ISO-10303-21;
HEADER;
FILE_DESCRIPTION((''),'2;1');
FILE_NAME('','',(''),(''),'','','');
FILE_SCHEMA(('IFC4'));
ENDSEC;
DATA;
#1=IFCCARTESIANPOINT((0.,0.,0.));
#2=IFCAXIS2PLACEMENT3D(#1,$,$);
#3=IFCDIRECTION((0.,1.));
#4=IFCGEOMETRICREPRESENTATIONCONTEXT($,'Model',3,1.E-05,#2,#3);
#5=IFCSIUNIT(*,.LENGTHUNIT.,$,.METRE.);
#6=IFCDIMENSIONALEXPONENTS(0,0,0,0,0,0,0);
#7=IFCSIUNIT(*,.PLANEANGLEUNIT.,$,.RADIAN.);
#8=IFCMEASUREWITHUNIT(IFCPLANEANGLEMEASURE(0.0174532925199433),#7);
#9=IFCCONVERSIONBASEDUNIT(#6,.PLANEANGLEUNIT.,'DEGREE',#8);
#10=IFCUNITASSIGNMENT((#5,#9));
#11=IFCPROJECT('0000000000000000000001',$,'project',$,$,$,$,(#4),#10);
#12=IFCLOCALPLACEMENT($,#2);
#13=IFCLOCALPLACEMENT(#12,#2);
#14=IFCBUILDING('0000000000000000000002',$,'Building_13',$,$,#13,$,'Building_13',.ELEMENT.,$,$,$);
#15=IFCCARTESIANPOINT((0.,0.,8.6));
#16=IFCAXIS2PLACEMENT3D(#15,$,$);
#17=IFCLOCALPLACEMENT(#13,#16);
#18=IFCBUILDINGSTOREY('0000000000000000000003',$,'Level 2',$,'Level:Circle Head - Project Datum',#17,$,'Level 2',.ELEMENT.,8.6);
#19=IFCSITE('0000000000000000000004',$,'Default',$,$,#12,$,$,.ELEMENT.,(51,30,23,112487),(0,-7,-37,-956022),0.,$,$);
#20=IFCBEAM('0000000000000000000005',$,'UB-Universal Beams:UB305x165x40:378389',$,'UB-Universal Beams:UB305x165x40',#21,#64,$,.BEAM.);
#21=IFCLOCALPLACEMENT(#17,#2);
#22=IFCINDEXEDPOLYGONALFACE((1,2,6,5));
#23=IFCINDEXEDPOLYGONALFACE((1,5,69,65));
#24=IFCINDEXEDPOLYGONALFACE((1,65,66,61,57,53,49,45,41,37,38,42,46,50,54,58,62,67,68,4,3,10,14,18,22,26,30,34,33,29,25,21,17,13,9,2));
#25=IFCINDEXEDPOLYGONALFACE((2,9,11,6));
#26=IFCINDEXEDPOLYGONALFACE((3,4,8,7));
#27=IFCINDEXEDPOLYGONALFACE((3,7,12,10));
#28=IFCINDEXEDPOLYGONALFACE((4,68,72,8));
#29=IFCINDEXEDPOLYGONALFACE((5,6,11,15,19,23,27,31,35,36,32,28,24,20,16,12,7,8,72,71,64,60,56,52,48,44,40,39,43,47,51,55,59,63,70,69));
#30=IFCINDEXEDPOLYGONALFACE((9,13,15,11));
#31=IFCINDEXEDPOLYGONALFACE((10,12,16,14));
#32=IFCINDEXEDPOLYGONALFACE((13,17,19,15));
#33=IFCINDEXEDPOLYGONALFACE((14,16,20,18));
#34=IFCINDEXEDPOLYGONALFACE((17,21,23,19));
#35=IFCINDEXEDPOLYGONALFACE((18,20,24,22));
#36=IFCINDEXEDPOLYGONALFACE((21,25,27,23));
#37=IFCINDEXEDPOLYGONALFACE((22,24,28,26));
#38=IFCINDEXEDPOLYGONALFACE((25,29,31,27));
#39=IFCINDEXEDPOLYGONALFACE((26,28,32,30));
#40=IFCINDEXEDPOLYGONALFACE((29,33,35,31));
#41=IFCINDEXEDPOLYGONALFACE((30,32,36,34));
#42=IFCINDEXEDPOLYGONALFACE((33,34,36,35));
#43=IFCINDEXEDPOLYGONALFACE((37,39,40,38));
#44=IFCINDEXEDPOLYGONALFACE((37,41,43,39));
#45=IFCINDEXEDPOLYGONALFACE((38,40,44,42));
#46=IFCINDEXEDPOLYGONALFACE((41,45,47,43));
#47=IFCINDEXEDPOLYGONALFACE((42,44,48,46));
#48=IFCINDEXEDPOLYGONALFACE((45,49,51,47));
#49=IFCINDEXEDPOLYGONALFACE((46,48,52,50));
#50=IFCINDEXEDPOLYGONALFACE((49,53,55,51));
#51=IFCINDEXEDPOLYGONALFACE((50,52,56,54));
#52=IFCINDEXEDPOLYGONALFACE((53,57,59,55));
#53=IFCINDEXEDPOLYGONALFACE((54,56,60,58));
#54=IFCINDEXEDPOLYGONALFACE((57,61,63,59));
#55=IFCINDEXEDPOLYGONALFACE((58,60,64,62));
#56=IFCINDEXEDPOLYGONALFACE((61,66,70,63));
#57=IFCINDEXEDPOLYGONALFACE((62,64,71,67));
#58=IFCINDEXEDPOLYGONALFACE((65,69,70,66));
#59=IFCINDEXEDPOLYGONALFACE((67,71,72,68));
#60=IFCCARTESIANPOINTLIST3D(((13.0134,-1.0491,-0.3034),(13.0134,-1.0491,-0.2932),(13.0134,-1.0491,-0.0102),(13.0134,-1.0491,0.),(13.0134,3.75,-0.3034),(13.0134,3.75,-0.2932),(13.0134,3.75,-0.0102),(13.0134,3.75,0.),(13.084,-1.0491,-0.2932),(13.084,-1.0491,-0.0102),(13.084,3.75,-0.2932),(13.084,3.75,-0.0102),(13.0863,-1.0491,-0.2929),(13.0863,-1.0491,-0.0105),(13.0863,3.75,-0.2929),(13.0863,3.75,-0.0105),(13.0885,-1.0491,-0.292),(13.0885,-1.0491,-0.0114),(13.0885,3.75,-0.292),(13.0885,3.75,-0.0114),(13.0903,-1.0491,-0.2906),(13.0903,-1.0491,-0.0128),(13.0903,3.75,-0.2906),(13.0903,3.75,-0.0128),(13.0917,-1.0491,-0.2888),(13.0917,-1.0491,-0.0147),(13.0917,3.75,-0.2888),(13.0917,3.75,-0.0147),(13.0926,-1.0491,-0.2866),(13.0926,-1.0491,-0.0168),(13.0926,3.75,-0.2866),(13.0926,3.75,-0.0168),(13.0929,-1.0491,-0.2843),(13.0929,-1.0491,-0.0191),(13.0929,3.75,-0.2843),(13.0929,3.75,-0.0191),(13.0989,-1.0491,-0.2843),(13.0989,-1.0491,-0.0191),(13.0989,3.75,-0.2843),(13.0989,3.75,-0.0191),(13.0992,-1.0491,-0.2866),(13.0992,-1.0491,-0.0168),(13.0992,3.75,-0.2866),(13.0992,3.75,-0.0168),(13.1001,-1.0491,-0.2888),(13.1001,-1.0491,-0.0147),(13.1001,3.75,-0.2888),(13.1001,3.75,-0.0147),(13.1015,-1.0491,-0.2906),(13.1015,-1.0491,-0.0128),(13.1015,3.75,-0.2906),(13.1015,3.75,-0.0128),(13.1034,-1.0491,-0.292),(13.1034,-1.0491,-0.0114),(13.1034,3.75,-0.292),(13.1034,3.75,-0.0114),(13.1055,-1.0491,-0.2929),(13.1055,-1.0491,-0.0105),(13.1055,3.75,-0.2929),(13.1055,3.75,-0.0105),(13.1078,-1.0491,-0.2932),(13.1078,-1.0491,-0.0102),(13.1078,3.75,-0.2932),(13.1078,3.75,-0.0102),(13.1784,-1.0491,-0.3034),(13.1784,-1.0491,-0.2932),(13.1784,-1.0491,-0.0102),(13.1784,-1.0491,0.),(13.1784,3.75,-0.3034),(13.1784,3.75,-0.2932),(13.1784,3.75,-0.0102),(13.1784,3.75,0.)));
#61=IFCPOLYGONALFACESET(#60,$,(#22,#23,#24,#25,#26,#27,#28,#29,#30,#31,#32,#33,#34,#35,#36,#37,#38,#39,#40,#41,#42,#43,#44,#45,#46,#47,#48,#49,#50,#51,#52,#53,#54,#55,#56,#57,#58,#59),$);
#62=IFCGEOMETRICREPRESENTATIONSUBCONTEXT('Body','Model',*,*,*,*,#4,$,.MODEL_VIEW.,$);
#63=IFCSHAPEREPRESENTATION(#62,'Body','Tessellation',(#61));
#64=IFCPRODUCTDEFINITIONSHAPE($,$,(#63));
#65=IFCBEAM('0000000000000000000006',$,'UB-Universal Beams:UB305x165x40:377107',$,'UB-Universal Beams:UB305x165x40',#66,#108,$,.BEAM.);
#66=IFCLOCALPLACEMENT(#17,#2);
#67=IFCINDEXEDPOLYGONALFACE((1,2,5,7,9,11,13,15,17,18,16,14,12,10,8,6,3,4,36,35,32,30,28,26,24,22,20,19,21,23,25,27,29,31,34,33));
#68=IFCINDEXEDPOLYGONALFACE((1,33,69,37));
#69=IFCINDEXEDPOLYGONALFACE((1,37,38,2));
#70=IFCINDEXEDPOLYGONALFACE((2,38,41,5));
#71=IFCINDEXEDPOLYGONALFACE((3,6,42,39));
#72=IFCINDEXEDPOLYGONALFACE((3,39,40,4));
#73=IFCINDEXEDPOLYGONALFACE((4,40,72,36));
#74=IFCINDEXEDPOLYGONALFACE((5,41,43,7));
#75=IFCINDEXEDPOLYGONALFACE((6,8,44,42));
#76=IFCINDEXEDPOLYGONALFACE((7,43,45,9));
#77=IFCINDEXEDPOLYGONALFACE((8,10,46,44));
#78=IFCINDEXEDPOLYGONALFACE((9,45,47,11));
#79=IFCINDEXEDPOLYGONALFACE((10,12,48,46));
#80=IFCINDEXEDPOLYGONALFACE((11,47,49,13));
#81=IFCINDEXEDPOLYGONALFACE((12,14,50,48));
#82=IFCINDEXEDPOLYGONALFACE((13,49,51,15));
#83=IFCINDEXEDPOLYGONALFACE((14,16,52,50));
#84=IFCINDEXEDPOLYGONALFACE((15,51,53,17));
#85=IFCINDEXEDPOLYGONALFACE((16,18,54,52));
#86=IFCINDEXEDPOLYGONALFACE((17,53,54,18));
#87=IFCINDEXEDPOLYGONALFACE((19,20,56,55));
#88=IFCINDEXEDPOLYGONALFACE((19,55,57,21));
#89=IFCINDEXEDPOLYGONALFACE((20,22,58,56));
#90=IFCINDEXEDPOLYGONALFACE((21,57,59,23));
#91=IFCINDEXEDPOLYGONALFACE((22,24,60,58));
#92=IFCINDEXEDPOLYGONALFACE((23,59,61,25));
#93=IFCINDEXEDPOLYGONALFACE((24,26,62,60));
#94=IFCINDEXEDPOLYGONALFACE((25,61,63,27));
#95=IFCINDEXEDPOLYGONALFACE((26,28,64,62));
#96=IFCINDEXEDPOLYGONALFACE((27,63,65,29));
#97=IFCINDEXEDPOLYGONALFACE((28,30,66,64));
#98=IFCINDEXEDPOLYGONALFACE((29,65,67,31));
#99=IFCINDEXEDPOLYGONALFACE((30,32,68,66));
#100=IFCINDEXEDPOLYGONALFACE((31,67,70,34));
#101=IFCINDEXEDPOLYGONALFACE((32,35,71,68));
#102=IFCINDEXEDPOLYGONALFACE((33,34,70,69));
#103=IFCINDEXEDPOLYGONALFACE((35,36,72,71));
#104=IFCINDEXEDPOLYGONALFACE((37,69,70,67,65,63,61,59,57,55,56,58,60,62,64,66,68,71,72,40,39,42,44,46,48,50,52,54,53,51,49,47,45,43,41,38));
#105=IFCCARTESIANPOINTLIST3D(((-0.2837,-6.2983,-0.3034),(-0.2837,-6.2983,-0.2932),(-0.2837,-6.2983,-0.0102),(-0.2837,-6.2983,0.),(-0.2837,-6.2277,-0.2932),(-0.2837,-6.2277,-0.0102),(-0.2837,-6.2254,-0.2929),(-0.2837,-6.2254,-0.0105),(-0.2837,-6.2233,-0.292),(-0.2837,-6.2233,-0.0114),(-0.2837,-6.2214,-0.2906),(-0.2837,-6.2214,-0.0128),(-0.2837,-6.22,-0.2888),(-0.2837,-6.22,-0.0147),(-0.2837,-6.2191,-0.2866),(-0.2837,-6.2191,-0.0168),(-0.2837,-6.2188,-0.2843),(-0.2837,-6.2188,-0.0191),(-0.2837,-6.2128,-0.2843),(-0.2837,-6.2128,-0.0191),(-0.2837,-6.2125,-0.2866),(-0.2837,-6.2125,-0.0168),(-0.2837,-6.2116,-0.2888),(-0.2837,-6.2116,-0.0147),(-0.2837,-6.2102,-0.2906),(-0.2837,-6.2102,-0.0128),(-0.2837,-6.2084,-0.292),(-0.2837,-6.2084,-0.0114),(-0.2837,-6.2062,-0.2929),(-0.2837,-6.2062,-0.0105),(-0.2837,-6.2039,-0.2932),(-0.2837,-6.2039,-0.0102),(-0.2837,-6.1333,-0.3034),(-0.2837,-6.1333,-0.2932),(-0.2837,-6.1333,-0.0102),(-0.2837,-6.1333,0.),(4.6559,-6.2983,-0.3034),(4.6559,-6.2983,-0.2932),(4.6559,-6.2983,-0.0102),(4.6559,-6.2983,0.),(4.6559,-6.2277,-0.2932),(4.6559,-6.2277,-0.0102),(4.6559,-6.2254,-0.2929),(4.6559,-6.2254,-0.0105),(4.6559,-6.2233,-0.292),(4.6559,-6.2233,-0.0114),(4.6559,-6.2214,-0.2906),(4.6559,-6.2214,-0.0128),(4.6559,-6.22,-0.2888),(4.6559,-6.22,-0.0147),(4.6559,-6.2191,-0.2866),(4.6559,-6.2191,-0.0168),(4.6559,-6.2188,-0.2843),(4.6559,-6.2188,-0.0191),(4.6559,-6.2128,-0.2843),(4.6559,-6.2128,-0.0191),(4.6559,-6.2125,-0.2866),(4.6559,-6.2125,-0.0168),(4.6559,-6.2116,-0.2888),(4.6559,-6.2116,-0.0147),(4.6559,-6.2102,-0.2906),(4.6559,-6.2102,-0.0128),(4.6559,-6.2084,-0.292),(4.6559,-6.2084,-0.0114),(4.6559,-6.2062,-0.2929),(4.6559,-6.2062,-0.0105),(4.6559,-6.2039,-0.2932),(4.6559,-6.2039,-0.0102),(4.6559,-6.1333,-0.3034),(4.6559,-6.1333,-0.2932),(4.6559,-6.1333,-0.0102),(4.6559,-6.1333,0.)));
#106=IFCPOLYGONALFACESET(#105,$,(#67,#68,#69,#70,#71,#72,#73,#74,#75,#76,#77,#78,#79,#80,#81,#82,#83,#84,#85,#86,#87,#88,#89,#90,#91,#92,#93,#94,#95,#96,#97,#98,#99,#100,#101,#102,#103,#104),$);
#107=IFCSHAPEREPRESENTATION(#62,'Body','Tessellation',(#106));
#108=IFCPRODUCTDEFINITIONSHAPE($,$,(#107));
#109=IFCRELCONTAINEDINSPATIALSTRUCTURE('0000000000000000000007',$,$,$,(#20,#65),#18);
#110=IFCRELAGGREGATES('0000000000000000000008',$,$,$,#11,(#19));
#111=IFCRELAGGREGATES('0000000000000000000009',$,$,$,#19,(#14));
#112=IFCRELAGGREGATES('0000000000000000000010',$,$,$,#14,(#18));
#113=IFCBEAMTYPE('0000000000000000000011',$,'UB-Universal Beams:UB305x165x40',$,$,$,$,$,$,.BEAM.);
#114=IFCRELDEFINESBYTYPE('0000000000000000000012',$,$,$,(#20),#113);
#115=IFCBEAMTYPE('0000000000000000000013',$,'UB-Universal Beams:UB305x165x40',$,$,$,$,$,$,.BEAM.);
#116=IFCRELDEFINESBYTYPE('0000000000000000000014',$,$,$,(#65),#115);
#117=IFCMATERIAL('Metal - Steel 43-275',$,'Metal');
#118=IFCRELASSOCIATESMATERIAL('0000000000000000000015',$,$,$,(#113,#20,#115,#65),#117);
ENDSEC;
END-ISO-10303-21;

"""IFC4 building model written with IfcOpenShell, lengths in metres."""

from ifc_helpers import new_model, entity, si_unit, converted_unit, direction, frame, origin, place, context, subcontext, project, spatial, line, arc, indexed_curve, outline, extrude, source, transform, mapped, material, type_object, type_shapes, element, save


model = new_model("IFC4")

# Units and contexts
model_context = context("Model", 3, precision=1e-05, world=origin(), true_north=direction((0.0, 1.0)))
body_context = subcontext(model_context, "Body", "Model", "MODEL_VIEW")
ifc_project = project(units=[si_unit("LENGTHUNIT", "METRE"), converted_unit("PLANEANGLEUNIT", "DEGREE", entity("IfcPlaneAngleMeasure", 0.0174532925199433), si_unit("PLANEANGLEUNIT", "RADIAN"), dimensions=[0, 0, 0, 0, 0, 0, 0])], contexts=[model_context])

# Site, building, storey
site_placement = place(None, origin())
site = spatial("IfcSite", under=ifc_project, at=site_placement, Name="Default", CompositionType="ELEMENT", RefLatitude=(51, 30, 23, 112487), RefLongitude=(0, -7, -37, -956022), RefElevation=0.0)
building_placement = place(site_placement, origin())
building = spatial("IfcBuilding", under=site, at=building_placement, Name="Building_13", LongName="Building_13", CompositionType="ELEMENT")
storey_placement = place(building_placement, frame((0.0, 0.0, 8.6)))
storey = spatial("IfcBuildingStorey", under=building, at=storey_placement, Name="Level 2", ObjectType="Level:Circle Head - Project Datum", LongName="Level 2", CompositionType="ELEMENT", Elevation=8.6)

# Beams
ifc_material_1 = material(Name="Metal - Steel 43-275", Category="Metal")
beam_type_1 = type_object("IfcBeamType", Name="UB-Universal Beams:UB305x165x40", PredefinedType="BEAM", material=ifc_material_1)
shared_shape_1 = source(origin(), body_context, "Body", "SweptSolid", [
    extrude(outline(indexed_curve([(-0.0825, -0.1415), (-0.0825, -0.1517), (0.0825, -0.1517), (0.0825, -0.1415), (0.0119, -0.1415), (0.0056, -0.1389), (0.003, -0.1326), (0.003, 0.1326), (0.0056, 0.1389), (0.0119, 0.1415), (0.0825, 0.1415), (0.0825, 0.1517), (-0.0825, 0.1517), (-0.0825, 0.1415), (-0.0119, 0.1415), (-0.0056, 0.1389), (-0.003, 0.1326), (-0.003, -0.1326), (-0.0056, -0.1389), (-0.0119, -0.1415)], segments=[line(1, 2, 3, 4, 5), arc(5, 6, 7), line(7, 8), arc(8, 9, 10), line(10, 11, 12, 13, 14, 15), arc(15, 16, 17), line(17, 18), arc(18, 19, 20), line(20, 1)], self_intersect=False)), frame((-2.3996, 0.0, 0.0), z_axis=(-1.0, 0.0, 0.0), x_axis=(0.0, -1.0, 0.0)), (0.0, 0.0, -1.0), 4.7991),
])
type_shapes(beam_type_1, [shared_shape_1])
for number, where, z_axis, x_axis, name in (
    (1, (13.0959, 1.3504, -0.1517), (0.0, 0.0, 1.0), (0.0, -1.0, 0.0), "UB-Universal Beams:UB305x165x40:378389"),
):
    element("IfcBeam", number, at=place(storey_placement, frame(where, z_axis=z_axis, x_axis=x_axis)), inside=storey, type_object=beam_type_1, material=ifc_material_1, Name=name, ObjectType="UB-Universal Beams:UB305x165x40", PredefinedType="BEAM", context=body_context, shape_type="MappedRepresentation", body=[
        mapped(shared_shape_1, transform((0.0, 0.0, 0.0), scale=1.0)),
    ])
beam_type_2 = type_object("IfcBeamType", Name="UB-Universal Beams:UB305x165x40", PredefinedType="BEAM", material=ifc_material_1)
shared_shape_2 = source(origin(), body_context, "Body", "SweptSolid", [
    extrude(outline(indexed_curve([(-0.0825, -0.1415), (-0.0825, -0.1517), (0.0825, -0.1517), (0.0825, -0.1415), (0.0119, -0.1415), (0.0056, -0.1389), (0.003, -0.1326), (0.003, 0.1326), (0.0056, 0.1389), (0.0119, 0.1415), (0.0825, 0.1415), (0.0825, 0.1517), (-0.0825, 0.1517), (-0.0825, 0.1415), (-0.0119, 0.1415), (-0.0056, 0.1389), (-0.003, 0.1326), (-0.003, -0.1326), (-0.0056, -0.1389), (-0.0119, -0.1415)], segments=[line(1, 2, 3, 4, 5), arc(5, 6, 7), line(7, 8), arc(8, 9, 10), line(10, 11, 12, 13, 14, 15), arc(15, 16, 17), line(17, 18), arc(18, 19, 20), line(20, 1)], self_intersect=False)), frame((-2.3846, 0.0, 0.0), z_axis=(-1.0, 0.0, 0.0), x_axis=(0.0, -1.0, 0.0)), (0.0, 0.0, -1.0), 4.9396),
])
type_shapes(beam_type_2, [shared_shape_2])
beam_1_placement = place(storey_placement, frame((2.1009, -6.2158, -0.1517)))
element("IfcBeam", 2, at=beam_1_placement, inside=storey, type_object=beam_type_2, material=ifc_material_1, Name="UB-Universal Beams:UB305x165x40:377107", ObjectType="UB-Universal Beams:UB305x165x40", PredefinedType="BEAM", context=body_context, shape_type="MappedRepresentation", body=[
    mapped(shared_shape_2, transform((0.0, 0.0, 0.0), scale=1.0)),
])

save(model, "model.ifc")
